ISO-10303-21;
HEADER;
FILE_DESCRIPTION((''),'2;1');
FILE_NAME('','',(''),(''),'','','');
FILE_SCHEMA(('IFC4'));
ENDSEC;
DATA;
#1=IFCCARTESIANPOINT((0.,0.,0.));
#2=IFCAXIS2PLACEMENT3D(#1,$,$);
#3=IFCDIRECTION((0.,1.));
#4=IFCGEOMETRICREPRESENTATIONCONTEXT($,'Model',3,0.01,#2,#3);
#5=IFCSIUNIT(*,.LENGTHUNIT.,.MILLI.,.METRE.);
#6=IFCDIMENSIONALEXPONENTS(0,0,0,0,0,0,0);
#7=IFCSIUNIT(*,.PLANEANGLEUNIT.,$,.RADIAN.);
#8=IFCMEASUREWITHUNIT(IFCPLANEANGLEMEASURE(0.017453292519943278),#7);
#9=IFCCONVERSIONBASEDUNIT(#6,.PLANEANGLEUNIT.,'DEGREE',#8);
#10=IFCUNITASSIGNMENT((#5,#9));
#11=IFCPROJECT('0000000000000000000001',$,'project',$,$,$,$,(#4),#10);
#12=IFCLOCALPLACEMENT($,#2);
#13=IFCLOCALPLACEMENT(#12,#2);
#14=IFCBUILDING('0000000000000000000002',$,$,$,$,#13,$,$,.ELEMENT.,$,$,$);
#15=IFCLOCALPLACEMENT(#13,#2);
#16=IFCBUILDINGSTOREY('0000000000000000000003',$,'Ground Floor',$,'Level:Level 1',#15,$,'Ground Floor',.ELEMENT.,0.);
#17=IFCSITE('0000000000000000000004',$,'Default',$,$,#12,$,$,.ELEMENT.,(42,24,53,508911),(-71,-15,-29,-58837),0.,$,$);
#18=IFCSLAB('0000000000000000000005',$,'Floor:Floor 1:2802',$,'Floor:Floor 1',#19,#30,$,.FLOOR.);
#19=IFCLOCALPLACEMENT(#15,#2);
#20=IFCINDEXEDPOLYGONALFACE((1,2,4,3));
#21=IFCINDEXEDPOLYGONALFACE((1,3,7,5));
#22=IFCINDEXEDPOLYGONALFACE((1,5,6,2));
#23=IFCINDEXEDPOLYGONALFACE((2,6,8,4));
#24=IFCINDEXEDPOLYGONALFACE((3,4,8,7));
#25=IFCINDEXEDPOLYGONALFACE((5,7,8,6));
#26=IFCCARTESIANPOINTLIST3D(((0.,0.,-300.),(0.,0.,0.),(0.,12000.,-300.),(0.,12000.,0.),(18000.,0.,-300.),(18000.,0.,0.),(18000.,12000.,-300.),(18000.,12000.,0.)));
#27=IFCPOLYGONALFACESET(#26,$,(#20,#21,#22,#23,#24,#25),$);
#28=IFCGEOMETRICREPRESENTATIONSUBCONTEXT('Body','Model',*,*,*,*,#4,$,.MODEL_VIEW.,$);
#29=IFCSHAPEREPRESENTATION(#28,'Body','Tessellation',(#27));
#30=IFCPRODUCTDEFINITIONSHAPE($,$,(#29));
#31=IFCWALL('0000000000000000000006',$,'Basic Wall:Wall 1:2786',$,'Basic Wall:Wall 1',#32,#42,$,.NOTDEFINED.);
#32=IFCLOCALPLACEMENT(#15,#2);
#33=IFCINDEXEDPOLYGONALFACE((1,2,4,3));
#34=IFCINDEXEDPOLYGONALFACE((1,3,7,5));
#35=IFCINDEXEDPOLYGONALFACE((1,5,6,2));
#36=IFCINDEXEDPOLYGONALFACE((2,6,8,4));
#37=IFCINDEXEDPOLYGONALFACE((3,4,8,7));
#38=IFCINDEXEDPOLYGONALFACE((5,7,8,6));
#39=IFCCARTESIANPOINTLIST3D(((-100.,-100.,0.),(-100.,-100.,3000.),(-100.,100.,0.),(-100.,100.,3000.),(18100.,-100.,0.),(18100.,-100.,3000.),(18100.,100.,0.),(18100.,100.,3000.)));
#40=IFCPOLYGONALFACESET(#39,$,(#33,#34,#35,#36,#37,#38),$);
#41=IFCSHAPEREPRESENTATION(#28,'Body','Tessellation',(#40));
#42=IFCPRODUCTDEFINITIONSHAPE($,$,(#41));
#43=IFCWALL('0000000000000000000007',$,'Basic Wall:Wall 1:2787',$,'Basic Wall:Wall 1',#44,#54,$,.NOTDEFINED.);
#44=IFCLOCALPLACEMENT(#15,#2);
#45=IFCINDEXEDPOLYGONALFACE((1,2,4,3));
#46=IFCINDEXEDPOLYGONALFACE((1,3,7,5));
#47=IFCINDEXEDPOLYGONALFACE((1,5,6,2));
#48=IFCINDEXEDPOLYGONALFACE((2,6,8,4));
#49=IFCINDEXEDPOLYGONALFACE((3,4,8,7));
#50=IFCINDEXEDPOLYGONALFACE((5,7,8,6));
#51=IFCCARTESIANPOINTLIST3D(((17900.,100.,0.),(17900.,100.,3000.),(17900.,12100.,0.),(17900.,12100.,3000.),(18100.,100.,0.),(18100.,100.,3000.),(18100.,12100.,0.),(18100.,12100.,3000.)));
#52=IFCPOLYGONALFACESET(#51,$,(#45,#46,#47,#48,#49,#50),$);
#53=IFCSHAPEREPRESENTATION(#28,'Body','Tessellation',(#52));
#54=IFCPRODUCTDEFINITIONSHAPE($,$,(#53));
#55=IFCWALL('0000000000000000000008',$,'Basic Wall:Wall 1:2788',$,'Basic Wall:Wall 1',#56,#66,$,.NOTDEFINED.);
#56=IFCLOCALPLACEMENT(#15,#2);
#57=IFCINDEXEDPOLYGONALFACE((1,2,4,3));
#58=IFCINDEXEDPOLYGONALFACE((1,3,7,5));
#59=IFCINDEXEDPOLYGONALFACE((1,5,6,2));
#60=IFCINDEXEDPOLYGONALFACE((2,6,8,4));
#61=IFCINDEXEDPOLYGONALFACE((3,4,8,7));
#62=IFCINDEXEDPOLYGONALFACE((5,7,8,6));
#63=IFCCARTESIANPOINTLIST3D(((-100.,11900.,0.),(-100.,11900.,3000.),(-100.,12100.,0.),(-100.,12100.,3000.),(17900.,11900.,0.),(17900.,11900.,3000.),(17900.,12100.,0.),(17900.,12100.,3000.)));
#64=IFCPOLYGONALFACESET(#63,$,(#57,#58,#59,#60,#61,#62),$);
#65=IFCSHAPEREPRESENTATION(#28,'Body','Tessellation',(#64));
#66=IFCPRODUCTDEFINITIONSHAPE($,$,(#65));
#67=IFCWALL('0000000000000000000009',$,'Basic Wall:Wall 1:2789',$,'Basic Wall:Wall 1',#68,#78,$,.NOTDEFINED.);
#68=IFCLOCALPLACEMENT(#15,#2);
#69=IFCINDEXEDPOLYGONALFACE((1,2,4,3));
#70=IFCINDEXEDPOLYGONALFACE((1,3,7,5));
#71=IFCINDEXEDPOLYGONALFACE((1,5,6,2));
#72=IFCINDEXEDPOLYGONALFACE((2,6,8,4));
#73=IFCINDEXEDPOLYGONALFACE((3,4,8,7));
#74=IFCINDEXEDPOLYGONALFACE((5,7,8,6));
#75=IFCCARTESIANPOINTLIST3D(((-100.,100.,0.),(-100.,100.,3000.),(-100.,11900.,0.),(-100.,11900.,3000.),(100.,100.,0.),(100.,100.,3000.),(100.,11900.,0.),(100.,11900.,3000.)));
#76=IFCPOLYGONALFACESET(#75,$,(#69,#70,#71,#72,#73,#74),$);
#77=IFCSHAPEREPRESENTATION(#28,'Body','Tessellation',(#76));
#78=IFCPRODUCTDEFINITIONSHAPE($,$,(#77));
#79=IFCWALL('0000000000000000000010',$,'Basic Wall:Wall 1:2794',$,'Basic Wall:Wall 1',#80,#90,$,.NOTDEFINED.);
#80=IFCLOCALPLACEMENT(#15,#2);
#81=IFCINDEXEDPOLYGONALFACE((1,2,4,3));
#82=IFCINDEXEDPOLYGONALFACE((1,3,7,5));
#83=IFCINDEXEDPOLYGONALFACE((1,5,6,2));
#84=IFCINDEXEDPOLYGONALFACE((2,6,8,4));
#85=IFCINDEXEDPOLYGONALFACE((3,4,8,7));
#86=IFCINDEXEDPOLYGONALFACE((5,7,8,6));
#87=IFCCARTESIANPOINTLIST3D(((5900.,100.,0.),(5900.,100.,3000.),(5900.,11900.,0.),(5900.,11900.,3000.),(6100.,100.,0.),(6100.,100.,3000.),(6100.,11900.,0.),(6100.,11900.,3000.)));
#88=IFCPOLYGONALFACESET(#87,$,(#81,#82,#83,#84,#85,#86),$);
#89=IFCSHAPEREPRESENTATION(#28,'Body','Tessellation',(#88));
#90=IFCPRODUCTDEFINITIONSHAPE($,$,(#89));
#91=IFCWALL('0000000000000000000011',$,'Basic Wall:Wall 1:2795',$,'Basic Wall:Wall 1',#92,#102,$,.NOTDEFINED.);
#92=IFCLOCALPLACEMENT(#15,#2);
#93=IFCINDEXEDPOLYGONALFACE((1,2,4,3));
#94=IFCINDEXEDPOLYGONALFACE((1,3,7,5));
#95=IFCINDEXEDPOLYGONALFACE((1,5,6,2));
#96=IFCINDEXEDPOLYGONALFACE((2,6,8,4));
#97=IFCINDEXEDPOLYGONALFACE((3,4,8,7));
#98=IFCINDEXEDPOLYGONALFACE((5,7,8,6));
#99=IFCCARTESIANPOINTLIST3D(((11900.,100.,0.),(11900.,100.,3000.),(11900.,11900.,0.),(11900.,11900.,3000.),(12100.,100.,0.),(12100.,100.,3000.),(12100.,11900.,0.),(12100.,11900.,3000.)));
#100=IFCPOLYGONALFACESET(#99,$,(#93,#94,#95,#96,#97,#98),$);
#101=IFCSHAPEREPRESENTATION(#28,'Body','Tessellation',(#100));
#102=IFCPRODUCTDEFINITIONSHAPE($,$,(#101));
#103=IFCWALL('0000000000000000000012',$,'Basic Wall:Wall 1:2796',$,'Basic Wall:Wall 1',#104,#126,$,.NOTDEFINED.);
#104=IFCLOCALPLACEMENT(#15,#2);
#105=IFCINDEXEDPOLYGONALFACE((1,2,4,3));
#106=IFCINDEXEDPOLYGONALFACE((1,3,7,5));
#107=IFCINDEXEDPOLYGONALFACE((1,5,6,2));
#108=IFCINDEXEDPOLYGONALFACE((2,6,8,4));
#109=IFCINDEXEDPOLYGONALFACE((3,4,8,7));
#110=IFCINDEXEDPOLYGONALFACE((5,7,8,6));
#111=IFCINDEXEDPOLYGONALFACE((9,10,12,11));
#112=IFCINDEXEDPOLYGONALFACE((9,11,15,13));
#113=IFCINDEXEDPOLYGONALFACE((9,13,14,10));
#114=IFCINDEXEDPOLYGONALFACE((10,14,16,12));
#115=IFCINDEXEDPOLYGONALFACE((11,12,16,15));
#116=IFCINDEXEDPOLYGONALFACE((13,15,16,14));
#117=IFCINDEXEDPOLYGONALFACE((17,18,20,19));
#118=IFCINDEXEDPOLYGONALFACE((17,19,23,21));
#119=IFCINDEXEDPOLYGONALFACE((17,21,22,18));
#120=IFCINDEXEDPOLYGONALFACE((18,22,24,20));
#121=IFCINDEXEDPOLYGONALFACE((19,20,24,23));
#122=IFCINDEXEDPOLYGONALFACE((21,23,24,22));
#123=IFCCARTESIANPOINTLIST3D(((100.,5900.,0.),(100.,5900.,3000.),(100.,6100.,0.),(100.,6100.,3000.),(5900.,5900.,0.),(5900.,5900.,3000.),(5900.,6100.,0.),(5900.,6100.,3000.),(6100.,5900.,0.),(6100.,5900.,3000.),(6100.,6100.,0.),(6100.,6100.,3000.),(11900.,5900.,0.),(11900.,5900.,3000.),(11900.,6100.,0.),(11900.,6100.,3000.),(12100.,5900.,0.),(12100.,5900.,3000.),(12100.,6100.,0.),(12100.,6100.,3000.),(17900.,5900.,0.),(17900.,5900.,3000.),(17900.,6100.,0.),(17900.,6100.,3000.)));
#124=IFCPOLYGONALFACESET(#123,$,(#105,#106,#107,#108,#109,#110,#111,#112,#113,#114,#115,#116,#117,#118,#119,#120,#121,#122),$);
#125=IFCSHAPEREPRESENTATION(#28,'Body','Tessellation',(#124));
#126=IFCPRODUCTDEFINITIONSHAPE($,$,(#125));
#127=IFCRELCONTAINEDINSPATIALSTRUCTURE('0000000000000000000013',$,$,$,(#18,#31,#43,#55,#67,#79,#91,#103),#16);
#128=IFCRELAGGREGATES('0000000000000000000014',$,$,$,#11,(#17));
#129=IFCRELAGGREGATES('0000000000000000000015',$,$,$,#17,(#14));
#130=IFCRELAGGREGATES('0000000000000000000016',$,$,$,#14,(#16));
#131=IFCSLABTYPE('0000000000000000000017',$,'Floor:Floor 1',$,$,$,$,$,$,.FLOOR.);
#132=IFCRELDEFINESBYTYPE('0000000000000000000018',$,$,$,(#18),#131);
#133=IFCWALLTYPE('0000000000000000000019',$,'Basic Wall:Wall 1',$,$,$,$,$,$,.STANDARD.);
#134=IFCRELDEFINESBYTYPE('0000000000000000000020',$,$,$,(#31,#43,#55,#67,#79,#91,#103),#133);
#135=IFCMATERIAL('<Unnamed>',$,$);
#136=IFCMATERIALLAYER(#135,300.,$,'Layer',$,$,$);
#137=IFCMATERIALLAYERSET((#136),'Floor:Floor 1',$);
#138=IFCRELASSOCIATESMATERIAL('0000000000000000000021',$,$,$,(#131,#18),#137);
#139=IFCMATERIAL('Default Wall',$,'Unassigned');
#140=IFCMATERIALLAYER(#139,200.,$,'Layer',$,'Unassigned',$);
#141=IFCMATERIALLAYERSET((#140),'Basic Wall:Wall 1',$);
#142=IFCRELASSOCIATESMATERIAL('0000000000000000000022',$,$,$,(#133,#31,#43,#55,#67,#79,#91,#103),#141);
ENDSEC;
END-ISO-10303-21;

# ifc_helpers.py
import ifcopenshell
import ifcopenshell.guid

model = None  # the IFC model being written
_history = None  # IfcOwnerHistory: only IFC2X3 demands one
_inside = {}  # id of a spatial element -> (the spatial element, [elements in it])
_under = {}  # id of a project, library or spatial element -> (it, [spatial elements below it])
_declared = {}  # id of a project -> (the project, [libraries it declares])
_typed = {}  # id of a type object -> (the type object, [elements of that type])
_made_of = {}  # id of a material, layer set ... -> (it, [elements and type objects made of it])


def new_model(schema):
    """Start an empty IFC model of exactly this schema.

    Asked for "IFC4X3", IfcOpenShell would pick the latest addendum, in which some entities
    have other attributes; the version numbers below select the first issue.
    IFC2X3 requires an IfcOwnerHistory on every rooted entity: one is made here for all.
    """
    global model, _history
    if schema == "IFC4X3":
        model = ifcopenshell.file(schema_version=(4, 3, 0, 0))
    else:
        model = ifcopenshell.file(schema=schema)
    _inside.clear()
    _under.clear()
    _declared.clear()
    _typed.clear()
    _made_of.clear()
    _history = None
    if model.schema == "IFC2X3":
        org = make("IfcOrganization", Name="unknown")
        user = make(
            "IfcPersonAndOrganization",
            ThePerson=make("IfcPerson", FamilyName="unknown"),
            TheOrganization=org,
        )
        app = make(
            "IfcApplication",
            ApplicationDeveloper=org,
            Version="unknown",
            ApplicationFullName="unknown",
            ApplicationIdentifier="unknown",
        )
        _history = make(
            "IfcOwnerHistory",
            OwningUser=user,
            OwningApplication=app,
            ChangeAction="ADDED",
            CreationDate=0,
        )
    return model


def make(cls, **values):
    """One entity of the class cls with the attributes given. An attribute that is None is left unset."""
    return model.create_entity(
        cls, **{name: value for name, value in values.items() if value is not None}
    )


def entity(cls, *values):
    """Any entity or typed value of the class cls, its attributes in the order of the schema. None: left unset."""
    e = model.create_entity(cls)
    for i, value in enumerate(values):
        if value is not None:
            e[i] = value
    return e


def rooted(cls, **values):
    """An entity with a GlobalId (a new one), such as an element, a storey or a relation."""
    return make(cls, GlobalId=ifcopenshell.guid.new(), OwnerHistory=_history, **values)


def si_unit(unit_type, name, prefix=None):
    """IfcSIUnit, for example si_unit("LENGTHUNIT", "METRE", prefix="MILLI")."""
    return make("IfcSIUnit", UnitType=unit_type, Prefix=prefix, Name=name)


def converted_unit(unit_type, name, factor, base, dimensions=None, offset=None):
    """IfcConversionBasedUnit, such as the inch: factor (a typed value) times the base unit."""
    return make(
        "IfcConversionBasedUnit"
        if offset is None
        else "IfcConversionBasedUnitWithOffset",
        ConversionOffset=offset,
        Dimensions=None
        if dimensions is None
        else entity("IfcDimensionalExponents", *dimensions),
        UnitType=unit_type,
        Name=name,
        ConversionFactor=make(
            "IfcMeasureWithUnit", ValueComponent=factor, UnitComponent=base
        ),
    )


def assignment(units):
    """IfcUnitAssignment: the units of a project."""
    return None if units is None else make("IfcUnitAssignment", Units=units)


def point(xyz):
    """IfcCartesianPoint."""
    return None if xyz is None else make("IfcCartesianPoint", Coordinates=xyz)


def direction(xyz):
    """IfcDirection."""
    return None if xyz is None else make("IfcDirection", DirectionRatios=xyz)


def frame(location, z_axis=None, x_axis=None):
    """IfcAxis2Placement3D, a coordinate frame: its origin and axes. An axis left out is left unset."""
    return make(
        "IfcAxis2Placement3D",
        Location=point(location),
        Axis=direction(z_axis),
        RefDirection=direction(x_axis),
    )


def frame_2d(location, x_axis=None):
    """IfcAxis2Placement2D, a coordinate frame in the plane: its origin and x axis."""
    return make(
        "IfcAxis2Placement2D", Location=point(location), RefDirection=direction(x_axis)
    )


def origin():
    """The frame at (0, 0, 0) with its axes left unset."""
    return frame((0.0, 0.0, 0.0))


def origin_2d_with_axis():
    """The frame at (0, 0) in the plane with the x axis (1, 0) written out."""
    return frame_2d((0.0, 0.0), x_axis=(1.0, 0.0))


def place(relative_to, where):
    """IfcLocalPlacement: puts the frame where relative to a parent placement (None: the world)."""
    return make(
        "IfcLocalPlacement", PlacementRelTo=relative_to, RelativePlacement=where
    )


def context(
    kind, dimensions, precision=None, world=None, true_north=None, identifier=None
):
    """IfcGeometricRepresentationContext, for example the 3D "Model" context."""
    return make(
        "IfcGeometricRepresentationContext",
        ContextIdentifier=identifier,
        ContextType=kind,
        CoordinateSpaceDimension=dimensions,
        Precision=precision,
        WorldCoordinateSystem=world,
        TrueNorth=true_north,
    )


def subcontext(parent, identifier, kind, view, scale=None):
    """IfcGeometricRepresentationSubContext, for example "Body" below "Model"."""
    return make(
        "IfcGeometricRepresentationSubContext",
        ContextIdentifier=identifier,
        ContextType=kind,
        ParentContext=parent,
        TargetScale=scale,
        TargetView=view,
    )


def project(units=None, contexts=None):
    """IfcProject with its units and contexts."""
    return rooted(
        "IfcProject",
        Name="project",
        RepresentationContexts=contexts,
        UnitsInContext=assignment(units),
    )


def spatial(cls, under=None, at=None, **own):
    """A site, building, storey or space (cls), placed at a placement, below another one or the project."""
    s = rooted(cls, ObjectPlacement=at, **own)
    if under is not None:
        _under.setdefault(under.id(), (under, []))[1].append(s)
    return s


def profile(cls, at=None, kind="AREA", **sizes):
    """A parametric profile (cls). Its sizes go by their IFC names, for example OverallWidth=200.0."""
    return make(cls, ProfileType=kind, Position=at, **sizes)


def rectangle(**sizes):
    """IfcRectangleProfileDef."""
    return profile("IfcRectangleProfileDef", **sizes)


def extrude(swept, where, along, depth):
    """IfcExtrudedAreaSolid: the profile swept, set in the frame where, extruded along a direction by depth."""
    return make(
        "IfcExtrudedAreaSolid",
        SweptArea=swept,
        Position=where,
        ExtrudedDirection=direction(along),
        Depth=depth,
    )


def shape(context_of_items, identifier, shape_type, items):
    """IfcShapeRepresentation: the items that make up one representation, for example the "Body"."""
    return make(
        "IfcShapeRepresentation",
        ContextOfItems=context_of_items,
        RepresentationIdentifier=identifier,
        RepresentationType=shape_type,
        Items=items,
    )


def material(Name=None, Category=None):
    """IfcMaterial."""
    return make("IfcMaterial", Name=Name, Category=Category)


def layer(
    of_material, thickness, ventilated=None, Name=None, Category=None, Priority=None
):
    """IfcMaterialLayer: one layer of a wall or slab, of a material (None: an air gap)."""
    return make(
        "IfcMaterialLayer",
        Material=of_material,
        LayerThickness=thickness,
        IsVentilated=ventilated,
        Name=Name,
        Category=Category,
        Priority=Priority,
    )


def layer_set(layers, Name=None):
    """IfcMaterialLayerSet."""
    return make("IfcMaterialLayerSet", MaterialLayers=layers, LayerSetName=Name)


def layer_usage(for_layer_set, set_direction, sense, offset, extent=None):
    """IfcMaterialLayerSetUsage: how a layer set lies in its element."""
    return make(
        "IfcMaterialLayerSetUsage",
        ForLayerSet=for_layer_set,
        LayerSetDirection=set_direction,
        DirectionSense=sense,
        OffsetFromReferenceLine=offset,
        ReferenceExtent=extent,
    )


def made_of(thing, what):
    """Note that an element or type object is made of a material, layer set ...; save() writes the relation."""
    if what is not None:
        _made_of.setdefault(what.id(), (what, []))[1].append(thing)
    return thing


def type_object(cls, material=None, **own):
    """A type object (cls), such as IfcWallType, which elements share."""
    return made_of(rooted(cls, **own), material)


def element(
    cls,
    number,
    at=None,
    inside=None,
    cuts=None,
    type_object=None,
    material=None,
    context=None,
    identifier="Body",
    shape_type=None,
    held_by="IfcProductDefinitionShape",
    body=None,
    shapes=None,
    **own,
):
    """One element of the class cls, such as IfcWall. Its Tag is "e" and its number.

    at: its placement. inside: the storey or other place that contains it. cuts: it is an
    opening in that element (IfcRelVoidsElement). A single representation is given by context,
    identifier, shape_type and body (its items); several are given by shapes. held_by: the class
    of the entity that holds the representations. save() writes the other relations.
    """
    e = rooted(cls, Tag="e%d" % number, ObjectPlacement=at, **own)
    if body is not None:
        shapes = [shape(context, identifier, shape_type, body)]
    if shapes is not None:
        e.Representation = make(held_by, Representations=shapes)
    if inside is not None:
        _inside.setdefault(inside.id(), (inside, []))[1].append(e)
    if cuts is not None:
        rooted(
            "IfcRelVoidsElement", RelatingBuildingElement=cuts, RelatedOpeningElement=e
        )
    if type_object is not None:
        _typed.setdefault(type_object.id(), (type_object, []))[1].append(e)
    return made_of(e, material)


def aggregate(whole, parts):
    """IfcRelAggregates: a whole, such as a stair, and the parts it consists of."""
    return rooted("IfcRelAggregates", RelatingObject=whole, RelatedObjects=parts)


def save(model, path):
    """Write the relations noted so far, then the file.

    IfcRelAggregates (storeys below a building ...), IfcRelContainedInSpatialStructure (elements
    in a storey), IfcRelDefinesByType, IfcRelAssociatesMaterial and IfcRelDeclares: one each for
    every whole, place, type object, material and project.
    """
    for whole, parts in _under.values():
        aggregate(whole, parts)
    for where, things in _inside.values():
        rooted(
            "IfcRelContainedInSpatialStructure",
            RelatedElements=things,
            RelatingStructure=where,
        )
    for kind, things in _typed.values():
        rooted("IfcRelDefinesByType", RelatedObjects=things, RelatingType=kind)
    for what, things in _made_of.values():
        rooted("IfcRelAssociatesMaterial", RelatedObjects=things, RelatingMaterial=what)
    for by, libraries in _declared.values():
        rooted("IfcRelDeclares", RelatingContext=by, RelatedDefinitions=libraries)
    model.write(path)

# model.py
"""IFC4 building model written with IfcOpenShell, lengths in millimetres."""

from ifc_helpers import new_model, entity, si_unit, converted_unit, direction, frame, frame_2d, origin, origin_2d_with_axis, place, context, subcontext, project, spatial, rectangle, extrude, material, layer, layer_set, layer_usage, type_object, element, save


model = new_model("IFC4")

# Units and contexts
model_context = context("Model", 3, precision=0.01, world=origin(), true_north=direction((0.0, 1.0)))
body_context = subcontext(model_context, "Body", "Model", "MODEL_VIEW")
ifc_project = project(units=[si_unit("LENGTHUNIT", "METRE", prefix="MILLI"), converted_unit("PLANEANGLEUNIT", "DEGREE", entity("IfcPlaneAngleMeasure", 0.017453292519943278), si_unit("PLANEANGLEUNIT", "RADIAN"), dimensions=[0, 0, 0, 0, 0, 0, 0])], contexts=[model_context])

# Site, building, storey
site_placement = place(None, origin())
site = spatial("IfcSite", under=ifc_project, at=site_placement, Name="Default", CompositionType="ELEMENT", RefLatitude=(42, 24, 53, 508911), RefLongitude=(-71, -15, -29, -58837), RefElevation=0.0)
building_placement = place(site_placement, origin())
building = spatial("IfcBuilding", under=site, at=building_placement, CompositionType="ELEMENT")
storey_placement = place(building_placement, origin())
storey = spatial("IfcBuildingStorey", under=building, at=storey_placement, Name="Ground Floor", ObjectType="Level:Level 1", LongName="Ground Floor", CompositionType="ELEMENT", Elevation=0.0)

# Slab
ifc_material_1 = material(Name="<Unnamed>")
ifc_layer_1 = layer(ifc_material_1, 300.0, Name="Layer")
ifc_layer_set_1 = layer_set([ifc_layer_1], Name="Floor:Floor 1")
ifc_layer_usage_1 = layer_usage(ifc_layer_set_1, "AXIS3", "POSITIVE", 0.0)
slab_type = type_object("IfcSlabType", Name="Floor:Floor 1", PredefinedType="FLOOR", material=ifc_layer_set_1)
slab_placement = place(storey_placement, origin())
element("IfcSlab", 1, at=slab_placement, inside=storey, type_object=slab_type, material=ifc_layer_usage_1, Name="Floor:Floor 1:2802", ObjectType="Floor:Floor 1", PredefinedType="FLOOR", context=body_context, shape_type="SweptSolid", body=[
    extrude(rectangle(XDim=12000.0, YDim=18000.0, at=origin_2d_with_axis()), frame((9000.0, 6000.0, 0.0), z_axis=(0.0, 0.0, -1.0), x_axis=(0.0, 1.0, 0.0)), (0.0, 0.0, 1.0), 300.0),
])

# Walls
ifc_material_2 = material(Name="Default Wall", Category="Unassigned")
ifc_layer_2 = layer(ifc_material_2, 200.0, Name="Layer", Category="Unassigned")
ifc_layer_set_2 = layer_set([ifc_layer_2], Name="Basic Wall:Wall 1")
ifc_layer_usage_2 = layer_usage(ifc_layer_set_2, "AXIS2", "NEGATIVE", 100.0)
wall_type = type_object("IfcWallType", Name="Basic Wall:Wall 1", PredefinedType="STANDARD", material=ifc_layer_set_2)
wall_1_placement = place(storey_placement, frame((-100.0, 0.0, 0.0)))
element("IfcWall", 2, at=wall_1_placement, inside=storey, type_object=wall_type, material=ifc_layer_usage_2, Name="Basic Wall:Wall 1:2786", ObjectType="Basic Wall:Wall 1", PredefinedType="NOTDEFINED", context=body_context, shape_type="SweptSolid", body=[
    extrude(rectangle(XDim=18200.0, YDim=200.0, at=frame_2d((9100.0, 0.0), x_axis=(-1.0, 0.0))), origin(), (0.0, 0.0, 1.0), 3000.0),
])
ifc_layer_usage_3 = layer_usage(ifc_layer_set_2, "AXIS2", "NEGATIVE", 100.0)
wall_2_placement = place(storey_placement, frame((18000.0, 100.0, 0.0), z_axis=(0.0, 0.0, 1.0), x_axis=(0.0, 1.0, 0.0)))
element("IfcWall", 3, at=wall_2_placement, inside=storey, type_object=wall_type, material=ifc_layer_usage_3, Name="Basic Wall:Wall 1:2787", ObjectType="Basic Wall:Wall 1", PredefinedType="NOTDEFINED", context=body_context, shape_type="SweptSolid", body=[
    extrude(rectangle(XDim=12000.0, YDim=200.0, at=frame_2d((6000.0, 0.0), x_axis=(-1.0, 0.0))), origin(), (0.0, 0.0, 1.0), 3000.0),
])
ifc_layer_usage_4 = layer_usage(ifc_layer_set_2, "AXIS2", "NEGATIVE", 100.0)
wall_3_placement = place(storey_placement, frame((17900.0, 12000.0, 0.0), z_axis=(0.0, 0.0, 1.0), x_axis=(-1.0, 0.0, 0.0)))
element("IfcWall", 4, at=wall_3_placement, inside=storey, type_object=wall_type, material=ifc_layer_usage_4, Name="Basic Wall:Wall 1:2788", ObjectType="Basic Wall:Wall 1", PredefinedType="NOTDEFINED", context=body_context, shape_type="SweptSolid", body=[
    extrude(rectangle(XDim=18000.0, YDim=200.0, at=frame_2d((9000.0, 0.0), x_axis=(-1.0, 0.0))), origin(), (0.0, 0.0, 1.0), 3000.0),
])
ifc_layer_usage_5 = layer_usage(ifc_layer_set_2, "AXIS2", "NEGATIVE", 100.0)
wall_4_placement = place(storey_placement, frame((0.0, 11900.0, 0.0), z_axis=(0.0, 0.0, 1.0), x_axis=(0.0, -1.0, 0.0)))
element("IfcWall", 5, at=wall_4_placement, inside=storey, type_object=wall_type, material=ifc_layer_usage_5, Name="Basic Wall:Wall 1:2789", ObjectType="Basic Wall:Wall 1", PredefinedType="NOTDEFINED", context=body_context, shape_type="SweptSolid", body=[
    extrude(rectangle(XDim=11800.0, YDim=200.0, at=frame_2d((5900.0, 0.0), x_axis=(-1.0, 0.0))), origin(), (0.0, 0.0, 1.0), 3000.0),
])
ifc_layer_usage_6 = layer_usage(ifc_layer_set_2, "AXIS2", "NEGATIVE", 100.0)
wall_5_placement = place(storey_placement, frame((6000.0, 100.0, 0.0), z_axis=(0.0, 0.0, 1.0), x_axis=(0.0, 1.0, 0.0)))
element("IfcWall", 6, at=wall_5_placement, inside=storey, type_object=wall_type, material=ifc_layer_usage_6, Name="Basic Wall:Wall 1:2794", ObjectType="Basic Wall:Wall 1", PredefinedType="NOTDEFINED", context=body_context, shape_type="SweptSolid", body=[
    extrude(rectangle(XDim=11800.0, YDim=200.0, at=frame_2d((5900.0, 0.0), x_axis=(-1.0, 0.0))), origin(), (0.0, 0.0, 1.0), 3000.0),
])
ifc_layer_usage_7 = layer_usage(ifc_layer_set_2, "AXIS2", "NEGATIVE", 100.0)
wall_6_placement = place(storey_placement, frame((12000.0, 100.0, 0.0), z_axis=(0.0, 0.0, 1.0), x_axis=(0.0, 1.0, 0.0)))
element("IfcWall", 7, at=wall_6_placement, inside=storey, type_object=wall_type, material=ifc_layer_usage_7, Name="Basic Wall:Wall 1:2795", ObjectType="Basic Wall:Wall 1", PredefinedType="NOTDEFINED", context=body_context, shape_type="SweptSolid", body=[
    extrude(rectangle(XDim=11800.0, YDim=200.0, at=frame_2d((5900.0, 0.0), x_axis=(-1.0, 0.0))), origin(), (0.0, 0.0, 1.0), 3000.0),
])

# Wall, openings
ifc_layer_usage_8 = layer_usage(ifc_layer_set_2, "AXIS2", "NEGATIVE", 100.0)
wall_7_placement = place(storey_placement, frame((100.0, 6000.0, 0.0)))
wall_7 = element("IfcWall", 8, at=wall_7_placement, inside=storey, type_object=wall_type, material=ifc_layer_usage_8, Name="Basic Wall:Wall 1:2796", ObjectType="Basic Wall:Wall 1", PredefinedType="NOTDEFINED", context=body_context, shape_type="SweptSolid", body=[
    extrude(rectangle(XDim=17800.0, YDim=200.0, at=frame_2d((8900.0, 0.0), x_axis=(-1.0, 0.0))), origin(), (0.0, 0.0, 1.0), 3000.0),
])
opening_1_placement = place(storey_placement, frame((100.0, 6000.0, 0.0)))
element("IfcOpeningElement", 9, at=opening_1_placement, cuts=wall_7, PredefinedType="OPENING", context=body_context, shape_type="SweptSolid", body=[
    extrude(rectangle(XDim=3000.0, YDim=200.0, at=origin_2d_with_axis()), frame((11800.0, 0.0, 1500.0), z_axis=(1.0, 0.0, 0.0), x_axis=(0.0, 0.0, -1.0)), (0.0, 0.0, 1.0), 200.0),
])
opening_2_placement = place(storey_placement, frame((100.0, 6000.0, 0.0)))
element("IfcOpeningElement", 10, at=opening_2_placement, cuts=wall_7, PredefinedType="OPENING", context=body_context, shape_type="SweptSolid", body=[
    extrude(rectangle(XDim=3000.0, YDim=200.0, at=origin_2d_with_axis()), frame((5800.0, 0.0, 1500.0), z_axis=(1.0, 0.0, 0.0), x_axis=(0.0, 0.0, -1.0)), (0.0, 0.0, 1.0), 200.0),
])

save(model, "model.ifc")
